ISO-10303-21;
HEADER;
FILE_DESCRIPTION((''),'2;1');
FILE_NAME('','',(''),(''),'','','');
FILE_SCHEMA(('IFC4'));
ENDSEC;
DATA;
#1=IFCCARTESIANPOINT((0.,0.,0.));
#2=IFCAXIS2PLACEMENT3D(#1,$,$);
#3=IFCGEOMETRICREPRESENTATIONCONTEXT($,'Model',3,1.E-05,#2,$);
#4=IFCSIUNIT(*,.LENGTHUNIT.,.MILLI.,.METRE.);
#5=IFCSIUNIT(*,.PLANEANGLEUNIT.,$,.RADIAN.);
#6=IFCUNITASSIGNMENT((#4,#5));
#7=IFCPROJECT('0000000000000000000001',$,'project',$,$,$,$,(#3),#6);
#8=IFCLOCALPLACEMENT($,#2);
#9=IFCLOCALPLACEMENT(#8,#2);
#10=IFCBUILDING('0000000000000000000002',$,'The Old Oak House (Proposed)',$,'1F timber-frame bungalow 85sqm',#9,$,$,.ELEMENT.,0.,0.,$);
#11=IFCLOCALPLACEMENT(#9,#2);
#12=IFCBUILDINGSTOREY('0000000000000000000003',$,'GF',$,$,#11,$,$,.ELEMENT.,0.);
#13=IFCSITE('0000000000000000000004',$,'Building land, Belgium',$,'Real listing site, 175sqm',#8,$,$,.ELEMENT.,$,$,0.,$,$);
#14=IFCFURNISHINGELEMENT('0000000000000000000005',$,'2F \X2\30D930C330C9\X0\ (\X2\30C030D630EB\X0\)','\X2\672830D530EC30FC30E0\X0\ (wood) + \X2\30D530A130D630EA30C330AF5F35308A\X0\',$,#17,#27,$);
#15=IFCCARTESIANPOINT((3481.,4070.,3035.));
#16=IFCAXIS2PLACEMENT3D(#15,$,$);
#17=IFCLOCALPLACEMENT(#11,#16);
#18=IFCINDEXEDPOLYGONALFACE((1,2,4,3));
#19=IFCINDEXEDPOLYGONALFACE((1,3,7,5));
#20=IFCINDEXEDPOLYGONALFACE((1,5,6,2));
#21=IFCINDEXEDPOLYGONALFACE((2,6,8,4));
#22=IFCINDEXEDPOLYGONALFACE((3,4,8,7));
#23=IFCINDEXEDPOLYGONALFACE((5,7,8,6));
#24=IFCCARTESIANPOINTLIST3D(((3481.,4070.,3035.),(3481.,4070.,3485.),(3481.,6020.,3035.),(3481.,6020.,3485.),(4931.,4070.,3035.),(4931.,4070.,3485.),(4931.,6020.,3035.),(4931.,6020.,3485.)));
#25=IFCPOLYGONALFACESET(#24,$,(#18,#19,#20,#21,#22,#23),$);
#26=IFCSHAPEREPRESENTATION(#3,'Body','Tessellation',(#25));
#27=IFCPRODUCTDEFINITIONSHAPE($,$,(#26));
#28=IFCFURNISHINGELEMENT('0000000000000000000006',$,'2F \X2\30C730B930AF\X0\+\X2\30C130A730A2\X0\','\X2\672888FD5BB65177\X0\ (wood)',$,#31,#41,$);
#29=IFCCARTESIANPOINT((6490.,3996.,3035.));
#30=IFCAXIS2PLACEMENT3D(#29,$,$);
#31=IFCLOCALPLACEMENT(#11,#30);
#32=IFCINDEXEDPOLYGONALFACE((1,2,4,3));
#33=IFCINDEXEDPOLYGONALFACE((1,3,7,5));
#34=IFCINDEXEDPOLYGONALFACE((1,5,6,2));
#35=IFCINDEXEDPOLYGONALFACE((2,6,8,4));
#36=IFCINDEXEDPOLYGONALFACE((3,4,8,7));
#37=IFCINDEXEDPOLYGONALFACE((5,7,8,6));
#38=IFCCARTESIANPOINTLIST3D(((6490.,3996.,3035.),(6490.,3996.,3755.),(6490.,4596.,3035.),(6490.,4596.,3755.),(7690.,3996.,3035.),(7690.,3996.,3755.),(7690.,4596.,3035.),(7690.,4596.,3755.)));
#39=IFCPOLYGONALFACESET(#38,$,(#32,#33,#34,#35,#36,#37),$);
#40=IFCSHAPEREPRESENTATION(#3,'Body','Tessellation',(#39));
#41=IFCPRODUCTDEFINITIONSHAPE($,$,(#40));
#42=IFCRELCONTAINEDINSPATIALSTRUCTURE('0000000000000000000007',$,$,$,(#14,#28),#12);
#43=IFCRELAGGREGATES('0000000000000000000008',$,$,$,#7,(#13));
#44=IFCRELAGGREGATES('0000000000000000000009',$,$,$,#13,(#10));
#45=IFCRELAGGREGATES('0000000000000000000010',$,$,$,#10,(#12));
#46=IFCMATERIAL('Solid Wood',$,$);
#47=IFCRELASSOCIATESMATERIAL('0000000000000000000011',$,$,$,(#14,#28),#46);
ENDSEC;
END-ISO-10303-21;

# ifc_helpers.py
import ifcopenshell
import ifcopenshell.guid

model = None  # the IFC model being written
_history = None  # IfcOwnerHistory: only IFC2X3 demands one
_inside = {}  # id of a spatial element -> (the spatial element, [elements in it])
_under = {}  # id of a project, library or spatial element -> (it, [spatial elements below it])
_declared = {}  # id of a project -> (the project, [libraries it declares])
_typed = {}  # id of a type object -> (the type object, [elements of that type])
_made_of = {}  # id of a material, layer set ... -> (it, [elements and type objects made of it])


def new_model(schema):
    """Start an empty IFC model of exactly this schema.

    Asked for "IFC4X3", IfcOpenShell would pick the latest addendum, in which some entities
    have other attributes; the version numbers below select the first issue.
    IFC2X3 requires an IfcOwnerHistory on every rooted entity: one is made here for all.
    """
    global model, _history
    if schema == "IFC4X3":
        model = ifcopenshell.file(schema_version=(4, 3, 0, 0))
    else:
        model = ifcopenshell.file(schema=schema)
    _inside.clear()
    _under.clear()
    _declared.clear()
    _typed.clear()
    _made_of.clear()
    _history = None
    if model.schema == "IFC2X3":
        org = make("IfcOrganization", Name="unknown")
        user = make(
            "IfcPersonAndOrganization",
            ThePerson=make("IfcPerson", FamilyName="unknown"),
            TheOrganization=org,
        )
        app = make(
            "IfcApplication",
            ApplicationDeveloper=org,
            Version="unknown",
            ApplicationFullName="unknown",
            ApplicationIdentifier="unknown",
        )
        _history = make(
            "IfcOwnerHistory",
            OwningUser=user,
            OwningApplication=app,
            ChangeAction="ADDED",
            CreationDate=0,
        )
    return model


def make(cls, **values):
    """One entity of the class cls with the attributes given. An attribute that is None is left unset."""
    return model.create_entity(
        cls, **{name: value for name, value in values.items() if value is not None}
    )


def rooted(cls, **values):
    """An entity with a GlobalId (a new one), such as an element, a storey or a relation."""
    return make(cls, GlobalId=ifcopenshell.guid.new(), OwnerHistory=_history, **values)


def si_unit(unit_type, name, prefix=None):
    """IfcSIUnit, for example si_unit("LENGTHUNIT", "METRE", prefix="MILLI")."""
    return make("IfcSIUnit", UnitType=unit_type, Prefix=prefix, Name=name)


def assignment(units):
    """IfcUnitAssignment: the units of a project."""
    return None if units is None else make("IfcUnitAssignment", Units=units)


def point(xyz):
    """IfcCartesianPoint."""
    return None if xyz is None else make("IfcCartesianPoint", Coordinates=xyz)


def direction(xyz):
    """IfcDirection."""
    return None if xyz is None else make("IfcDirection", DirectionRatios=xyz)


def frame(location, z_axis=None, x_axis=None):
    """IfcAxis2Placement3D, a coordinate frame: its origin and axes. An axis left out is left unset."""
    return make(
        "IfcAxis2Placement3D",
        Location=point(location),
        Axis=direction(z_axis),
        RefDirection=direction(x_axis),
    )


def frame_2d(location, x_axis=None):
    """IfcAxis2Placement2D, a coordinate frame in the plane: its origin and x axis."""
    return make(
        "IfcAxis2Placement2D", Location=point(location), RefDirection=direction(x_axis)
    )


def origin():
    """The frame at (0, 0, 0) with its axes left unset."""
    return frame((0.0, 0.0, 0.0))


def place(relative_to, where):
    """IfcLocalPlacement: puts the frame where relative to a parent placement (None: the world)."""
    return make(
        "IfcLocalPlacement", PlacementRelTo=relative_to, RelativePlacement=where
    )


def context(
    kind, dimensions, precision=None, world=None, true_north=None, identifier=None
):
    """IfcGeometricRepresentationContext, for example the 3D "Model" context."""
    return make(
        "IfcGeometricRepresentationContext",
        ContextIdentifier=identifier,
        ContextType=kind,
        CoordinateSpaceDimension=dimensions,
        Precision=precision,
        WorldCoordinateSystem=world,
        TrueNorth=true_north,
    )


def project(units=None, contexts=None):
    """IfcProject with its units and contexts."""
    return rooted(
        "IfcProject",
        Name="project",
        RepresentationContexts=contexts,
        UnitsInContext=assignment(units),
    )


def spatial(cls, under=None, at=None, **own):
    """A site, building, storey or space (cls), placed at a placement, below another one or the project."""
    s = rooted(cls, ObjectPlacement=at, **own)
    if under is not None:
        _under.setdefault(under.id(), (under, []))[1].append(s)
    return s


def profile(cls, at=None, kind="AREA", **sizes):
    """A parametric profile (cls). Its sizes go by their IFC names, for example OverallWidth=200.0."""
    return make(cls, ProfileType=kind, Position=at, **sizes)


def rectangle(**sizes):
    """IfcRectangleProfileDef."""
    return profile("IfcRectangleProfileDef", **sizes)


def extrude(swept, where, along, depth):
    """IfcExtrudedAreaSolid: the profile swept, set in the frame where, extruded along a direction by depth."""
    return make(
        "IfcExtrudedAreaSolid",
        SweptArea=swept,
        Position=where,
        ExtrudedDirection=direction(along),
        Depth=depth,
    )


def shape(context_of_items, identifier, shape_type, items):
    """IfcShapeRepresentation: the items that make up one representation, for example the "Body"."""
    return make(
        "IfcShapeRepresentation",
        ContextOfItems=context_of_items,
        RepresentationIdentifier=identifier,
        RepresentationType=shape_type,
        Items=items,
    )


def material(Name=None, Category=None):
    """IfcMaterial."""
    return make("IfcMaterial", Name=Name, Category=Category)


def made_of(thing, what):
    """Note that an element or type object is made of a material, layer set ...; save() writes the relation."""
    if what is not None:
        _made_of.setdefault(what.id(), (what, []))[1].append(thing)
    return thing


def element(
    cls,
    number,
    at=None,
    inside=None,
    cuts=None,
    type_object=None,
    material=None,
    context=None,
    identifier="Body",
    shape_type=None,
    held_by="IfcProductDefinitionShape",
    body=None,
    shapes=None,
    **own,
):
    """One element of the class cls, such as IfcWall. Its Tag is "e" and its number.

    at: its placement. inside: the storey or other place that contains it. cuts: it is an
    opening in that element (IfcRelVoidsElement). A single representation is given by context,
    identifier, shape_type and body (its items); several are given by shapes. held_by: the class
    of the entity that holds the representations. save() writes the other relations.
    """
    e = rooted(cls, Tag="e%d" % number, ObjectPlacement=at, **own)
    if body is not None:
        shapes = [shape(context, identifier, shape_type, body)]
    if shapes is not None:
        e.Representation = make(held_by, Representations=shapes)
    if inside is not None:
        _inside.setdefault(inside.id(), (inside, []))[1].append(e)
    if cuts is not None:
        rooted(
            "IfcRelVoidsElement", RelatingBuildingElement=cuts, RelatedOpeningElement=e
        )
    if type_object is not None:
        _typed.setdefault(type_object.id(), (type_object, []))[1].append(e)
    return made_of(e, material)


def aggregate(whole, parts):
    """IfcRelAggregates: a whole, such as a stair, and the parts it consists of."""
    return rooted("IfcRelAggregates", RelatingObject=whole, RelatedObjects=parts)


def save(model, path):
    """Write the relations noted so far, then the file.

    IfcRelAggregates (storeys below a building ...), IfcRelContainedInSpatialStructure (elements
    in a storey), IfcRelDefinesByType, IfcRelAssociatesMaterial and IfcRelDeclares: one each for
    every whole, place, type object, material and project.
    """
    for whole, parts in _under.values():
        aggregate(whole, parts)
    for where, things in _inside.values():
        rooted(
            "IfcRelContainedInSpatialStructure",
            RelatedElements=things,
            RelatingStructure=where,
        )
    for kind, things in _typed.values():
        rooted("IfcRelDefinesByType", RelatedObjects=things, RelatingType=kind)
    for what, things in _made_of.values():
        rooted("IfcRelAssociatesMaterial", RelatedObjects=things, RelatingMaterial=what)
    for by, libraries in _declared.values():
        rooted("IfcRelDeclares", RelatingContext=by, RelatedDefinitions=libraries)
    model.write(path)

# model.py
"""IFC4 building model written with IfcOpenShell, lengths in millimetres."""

from ifc_helpers import new_model, si_unit, frame, frame_2d, origin, place, context, project, spatial, rectangle, extrude, material, element, save


model = new_model("IFC4")

# Units and contexts
model_context = context("Model", 3, precision=1e-05, world=origin())
ifc_project = project(units=[si_unit("LENGTHUNIT", "METRE", prefix="MILLI"), si_unit("PLANEANGLEUNIT", "RADIAN")], contexts=[model_context])

# Site, building, storey
site_placement = place(None, origin())
site = spatial("IfcSite", under=ifc_project, at=site_placement, Name="Building land, Belgium", ObjectType="Real listing site, 175sqm", CompositionType="ELEMENT", RefElevation=0.0)
building_placement = place(site_placement, origin())
building = spatial("IfcBuilding", under=site, at=building_placement, Name="The Old Oak House (Proposed)", ObjectType="1F timber-frame bungalow 85sqm", CompositionType="ELEMENT", ElevationOfRefHeight=0.0, ElevationOfTerrain=0.0)
storey_placement = place(building_placement, origin())
storey = spatial("IfcBuildingStorey", under=building, at=storey_placement, Name="GF", CompositionType="ELEMENT", Elevation=0.0)

# Shared definitions
ifc_material_1 = material(Name="Solid Wood")

# Furnishing elements
furnishing_1_placement = place(storey_placement, frame((3481.0, 4070.0, 3035.0)))
element("IfcFurnishingElement", 1, at=furnishing_1_placement, inside=storey, material=ifc_material_1, Name="2F ベッド (ダブル)", Description="木フレーム (wood) + ファブリック張り", context=model_context, shape_type="SweptSolid", body=[
    extrude(rectangle(XDim=1450.0, YDim=1950.0, at=frame_2d((725.0, 975.0))), frame((3481.0, 4070.0, 3035.0)), (0.0, 0.0, 1.0), 450.0),
])
furnishing_2_placement = place(storey_placement, frame((6490.0, 3996.0, 3035.0)))
element("IfcFurnishingElement", 2, at=furnishing_2_placement, inside=storey, material=ifc_material_1, Name="2F デスク+チェア", Description="木製家具 (wood)", context=model_context, shape_type="SweptSolid", body=[
    extrude(rectangle(XDim=1200.0, YDim=600.0, at=frame_2d((600.0, 300.0))), frame((6490.0, 3996.0, 3035.0)), (0.0, 0.0, 1.0), 720.0),
])

save(model, "model.ifc")
